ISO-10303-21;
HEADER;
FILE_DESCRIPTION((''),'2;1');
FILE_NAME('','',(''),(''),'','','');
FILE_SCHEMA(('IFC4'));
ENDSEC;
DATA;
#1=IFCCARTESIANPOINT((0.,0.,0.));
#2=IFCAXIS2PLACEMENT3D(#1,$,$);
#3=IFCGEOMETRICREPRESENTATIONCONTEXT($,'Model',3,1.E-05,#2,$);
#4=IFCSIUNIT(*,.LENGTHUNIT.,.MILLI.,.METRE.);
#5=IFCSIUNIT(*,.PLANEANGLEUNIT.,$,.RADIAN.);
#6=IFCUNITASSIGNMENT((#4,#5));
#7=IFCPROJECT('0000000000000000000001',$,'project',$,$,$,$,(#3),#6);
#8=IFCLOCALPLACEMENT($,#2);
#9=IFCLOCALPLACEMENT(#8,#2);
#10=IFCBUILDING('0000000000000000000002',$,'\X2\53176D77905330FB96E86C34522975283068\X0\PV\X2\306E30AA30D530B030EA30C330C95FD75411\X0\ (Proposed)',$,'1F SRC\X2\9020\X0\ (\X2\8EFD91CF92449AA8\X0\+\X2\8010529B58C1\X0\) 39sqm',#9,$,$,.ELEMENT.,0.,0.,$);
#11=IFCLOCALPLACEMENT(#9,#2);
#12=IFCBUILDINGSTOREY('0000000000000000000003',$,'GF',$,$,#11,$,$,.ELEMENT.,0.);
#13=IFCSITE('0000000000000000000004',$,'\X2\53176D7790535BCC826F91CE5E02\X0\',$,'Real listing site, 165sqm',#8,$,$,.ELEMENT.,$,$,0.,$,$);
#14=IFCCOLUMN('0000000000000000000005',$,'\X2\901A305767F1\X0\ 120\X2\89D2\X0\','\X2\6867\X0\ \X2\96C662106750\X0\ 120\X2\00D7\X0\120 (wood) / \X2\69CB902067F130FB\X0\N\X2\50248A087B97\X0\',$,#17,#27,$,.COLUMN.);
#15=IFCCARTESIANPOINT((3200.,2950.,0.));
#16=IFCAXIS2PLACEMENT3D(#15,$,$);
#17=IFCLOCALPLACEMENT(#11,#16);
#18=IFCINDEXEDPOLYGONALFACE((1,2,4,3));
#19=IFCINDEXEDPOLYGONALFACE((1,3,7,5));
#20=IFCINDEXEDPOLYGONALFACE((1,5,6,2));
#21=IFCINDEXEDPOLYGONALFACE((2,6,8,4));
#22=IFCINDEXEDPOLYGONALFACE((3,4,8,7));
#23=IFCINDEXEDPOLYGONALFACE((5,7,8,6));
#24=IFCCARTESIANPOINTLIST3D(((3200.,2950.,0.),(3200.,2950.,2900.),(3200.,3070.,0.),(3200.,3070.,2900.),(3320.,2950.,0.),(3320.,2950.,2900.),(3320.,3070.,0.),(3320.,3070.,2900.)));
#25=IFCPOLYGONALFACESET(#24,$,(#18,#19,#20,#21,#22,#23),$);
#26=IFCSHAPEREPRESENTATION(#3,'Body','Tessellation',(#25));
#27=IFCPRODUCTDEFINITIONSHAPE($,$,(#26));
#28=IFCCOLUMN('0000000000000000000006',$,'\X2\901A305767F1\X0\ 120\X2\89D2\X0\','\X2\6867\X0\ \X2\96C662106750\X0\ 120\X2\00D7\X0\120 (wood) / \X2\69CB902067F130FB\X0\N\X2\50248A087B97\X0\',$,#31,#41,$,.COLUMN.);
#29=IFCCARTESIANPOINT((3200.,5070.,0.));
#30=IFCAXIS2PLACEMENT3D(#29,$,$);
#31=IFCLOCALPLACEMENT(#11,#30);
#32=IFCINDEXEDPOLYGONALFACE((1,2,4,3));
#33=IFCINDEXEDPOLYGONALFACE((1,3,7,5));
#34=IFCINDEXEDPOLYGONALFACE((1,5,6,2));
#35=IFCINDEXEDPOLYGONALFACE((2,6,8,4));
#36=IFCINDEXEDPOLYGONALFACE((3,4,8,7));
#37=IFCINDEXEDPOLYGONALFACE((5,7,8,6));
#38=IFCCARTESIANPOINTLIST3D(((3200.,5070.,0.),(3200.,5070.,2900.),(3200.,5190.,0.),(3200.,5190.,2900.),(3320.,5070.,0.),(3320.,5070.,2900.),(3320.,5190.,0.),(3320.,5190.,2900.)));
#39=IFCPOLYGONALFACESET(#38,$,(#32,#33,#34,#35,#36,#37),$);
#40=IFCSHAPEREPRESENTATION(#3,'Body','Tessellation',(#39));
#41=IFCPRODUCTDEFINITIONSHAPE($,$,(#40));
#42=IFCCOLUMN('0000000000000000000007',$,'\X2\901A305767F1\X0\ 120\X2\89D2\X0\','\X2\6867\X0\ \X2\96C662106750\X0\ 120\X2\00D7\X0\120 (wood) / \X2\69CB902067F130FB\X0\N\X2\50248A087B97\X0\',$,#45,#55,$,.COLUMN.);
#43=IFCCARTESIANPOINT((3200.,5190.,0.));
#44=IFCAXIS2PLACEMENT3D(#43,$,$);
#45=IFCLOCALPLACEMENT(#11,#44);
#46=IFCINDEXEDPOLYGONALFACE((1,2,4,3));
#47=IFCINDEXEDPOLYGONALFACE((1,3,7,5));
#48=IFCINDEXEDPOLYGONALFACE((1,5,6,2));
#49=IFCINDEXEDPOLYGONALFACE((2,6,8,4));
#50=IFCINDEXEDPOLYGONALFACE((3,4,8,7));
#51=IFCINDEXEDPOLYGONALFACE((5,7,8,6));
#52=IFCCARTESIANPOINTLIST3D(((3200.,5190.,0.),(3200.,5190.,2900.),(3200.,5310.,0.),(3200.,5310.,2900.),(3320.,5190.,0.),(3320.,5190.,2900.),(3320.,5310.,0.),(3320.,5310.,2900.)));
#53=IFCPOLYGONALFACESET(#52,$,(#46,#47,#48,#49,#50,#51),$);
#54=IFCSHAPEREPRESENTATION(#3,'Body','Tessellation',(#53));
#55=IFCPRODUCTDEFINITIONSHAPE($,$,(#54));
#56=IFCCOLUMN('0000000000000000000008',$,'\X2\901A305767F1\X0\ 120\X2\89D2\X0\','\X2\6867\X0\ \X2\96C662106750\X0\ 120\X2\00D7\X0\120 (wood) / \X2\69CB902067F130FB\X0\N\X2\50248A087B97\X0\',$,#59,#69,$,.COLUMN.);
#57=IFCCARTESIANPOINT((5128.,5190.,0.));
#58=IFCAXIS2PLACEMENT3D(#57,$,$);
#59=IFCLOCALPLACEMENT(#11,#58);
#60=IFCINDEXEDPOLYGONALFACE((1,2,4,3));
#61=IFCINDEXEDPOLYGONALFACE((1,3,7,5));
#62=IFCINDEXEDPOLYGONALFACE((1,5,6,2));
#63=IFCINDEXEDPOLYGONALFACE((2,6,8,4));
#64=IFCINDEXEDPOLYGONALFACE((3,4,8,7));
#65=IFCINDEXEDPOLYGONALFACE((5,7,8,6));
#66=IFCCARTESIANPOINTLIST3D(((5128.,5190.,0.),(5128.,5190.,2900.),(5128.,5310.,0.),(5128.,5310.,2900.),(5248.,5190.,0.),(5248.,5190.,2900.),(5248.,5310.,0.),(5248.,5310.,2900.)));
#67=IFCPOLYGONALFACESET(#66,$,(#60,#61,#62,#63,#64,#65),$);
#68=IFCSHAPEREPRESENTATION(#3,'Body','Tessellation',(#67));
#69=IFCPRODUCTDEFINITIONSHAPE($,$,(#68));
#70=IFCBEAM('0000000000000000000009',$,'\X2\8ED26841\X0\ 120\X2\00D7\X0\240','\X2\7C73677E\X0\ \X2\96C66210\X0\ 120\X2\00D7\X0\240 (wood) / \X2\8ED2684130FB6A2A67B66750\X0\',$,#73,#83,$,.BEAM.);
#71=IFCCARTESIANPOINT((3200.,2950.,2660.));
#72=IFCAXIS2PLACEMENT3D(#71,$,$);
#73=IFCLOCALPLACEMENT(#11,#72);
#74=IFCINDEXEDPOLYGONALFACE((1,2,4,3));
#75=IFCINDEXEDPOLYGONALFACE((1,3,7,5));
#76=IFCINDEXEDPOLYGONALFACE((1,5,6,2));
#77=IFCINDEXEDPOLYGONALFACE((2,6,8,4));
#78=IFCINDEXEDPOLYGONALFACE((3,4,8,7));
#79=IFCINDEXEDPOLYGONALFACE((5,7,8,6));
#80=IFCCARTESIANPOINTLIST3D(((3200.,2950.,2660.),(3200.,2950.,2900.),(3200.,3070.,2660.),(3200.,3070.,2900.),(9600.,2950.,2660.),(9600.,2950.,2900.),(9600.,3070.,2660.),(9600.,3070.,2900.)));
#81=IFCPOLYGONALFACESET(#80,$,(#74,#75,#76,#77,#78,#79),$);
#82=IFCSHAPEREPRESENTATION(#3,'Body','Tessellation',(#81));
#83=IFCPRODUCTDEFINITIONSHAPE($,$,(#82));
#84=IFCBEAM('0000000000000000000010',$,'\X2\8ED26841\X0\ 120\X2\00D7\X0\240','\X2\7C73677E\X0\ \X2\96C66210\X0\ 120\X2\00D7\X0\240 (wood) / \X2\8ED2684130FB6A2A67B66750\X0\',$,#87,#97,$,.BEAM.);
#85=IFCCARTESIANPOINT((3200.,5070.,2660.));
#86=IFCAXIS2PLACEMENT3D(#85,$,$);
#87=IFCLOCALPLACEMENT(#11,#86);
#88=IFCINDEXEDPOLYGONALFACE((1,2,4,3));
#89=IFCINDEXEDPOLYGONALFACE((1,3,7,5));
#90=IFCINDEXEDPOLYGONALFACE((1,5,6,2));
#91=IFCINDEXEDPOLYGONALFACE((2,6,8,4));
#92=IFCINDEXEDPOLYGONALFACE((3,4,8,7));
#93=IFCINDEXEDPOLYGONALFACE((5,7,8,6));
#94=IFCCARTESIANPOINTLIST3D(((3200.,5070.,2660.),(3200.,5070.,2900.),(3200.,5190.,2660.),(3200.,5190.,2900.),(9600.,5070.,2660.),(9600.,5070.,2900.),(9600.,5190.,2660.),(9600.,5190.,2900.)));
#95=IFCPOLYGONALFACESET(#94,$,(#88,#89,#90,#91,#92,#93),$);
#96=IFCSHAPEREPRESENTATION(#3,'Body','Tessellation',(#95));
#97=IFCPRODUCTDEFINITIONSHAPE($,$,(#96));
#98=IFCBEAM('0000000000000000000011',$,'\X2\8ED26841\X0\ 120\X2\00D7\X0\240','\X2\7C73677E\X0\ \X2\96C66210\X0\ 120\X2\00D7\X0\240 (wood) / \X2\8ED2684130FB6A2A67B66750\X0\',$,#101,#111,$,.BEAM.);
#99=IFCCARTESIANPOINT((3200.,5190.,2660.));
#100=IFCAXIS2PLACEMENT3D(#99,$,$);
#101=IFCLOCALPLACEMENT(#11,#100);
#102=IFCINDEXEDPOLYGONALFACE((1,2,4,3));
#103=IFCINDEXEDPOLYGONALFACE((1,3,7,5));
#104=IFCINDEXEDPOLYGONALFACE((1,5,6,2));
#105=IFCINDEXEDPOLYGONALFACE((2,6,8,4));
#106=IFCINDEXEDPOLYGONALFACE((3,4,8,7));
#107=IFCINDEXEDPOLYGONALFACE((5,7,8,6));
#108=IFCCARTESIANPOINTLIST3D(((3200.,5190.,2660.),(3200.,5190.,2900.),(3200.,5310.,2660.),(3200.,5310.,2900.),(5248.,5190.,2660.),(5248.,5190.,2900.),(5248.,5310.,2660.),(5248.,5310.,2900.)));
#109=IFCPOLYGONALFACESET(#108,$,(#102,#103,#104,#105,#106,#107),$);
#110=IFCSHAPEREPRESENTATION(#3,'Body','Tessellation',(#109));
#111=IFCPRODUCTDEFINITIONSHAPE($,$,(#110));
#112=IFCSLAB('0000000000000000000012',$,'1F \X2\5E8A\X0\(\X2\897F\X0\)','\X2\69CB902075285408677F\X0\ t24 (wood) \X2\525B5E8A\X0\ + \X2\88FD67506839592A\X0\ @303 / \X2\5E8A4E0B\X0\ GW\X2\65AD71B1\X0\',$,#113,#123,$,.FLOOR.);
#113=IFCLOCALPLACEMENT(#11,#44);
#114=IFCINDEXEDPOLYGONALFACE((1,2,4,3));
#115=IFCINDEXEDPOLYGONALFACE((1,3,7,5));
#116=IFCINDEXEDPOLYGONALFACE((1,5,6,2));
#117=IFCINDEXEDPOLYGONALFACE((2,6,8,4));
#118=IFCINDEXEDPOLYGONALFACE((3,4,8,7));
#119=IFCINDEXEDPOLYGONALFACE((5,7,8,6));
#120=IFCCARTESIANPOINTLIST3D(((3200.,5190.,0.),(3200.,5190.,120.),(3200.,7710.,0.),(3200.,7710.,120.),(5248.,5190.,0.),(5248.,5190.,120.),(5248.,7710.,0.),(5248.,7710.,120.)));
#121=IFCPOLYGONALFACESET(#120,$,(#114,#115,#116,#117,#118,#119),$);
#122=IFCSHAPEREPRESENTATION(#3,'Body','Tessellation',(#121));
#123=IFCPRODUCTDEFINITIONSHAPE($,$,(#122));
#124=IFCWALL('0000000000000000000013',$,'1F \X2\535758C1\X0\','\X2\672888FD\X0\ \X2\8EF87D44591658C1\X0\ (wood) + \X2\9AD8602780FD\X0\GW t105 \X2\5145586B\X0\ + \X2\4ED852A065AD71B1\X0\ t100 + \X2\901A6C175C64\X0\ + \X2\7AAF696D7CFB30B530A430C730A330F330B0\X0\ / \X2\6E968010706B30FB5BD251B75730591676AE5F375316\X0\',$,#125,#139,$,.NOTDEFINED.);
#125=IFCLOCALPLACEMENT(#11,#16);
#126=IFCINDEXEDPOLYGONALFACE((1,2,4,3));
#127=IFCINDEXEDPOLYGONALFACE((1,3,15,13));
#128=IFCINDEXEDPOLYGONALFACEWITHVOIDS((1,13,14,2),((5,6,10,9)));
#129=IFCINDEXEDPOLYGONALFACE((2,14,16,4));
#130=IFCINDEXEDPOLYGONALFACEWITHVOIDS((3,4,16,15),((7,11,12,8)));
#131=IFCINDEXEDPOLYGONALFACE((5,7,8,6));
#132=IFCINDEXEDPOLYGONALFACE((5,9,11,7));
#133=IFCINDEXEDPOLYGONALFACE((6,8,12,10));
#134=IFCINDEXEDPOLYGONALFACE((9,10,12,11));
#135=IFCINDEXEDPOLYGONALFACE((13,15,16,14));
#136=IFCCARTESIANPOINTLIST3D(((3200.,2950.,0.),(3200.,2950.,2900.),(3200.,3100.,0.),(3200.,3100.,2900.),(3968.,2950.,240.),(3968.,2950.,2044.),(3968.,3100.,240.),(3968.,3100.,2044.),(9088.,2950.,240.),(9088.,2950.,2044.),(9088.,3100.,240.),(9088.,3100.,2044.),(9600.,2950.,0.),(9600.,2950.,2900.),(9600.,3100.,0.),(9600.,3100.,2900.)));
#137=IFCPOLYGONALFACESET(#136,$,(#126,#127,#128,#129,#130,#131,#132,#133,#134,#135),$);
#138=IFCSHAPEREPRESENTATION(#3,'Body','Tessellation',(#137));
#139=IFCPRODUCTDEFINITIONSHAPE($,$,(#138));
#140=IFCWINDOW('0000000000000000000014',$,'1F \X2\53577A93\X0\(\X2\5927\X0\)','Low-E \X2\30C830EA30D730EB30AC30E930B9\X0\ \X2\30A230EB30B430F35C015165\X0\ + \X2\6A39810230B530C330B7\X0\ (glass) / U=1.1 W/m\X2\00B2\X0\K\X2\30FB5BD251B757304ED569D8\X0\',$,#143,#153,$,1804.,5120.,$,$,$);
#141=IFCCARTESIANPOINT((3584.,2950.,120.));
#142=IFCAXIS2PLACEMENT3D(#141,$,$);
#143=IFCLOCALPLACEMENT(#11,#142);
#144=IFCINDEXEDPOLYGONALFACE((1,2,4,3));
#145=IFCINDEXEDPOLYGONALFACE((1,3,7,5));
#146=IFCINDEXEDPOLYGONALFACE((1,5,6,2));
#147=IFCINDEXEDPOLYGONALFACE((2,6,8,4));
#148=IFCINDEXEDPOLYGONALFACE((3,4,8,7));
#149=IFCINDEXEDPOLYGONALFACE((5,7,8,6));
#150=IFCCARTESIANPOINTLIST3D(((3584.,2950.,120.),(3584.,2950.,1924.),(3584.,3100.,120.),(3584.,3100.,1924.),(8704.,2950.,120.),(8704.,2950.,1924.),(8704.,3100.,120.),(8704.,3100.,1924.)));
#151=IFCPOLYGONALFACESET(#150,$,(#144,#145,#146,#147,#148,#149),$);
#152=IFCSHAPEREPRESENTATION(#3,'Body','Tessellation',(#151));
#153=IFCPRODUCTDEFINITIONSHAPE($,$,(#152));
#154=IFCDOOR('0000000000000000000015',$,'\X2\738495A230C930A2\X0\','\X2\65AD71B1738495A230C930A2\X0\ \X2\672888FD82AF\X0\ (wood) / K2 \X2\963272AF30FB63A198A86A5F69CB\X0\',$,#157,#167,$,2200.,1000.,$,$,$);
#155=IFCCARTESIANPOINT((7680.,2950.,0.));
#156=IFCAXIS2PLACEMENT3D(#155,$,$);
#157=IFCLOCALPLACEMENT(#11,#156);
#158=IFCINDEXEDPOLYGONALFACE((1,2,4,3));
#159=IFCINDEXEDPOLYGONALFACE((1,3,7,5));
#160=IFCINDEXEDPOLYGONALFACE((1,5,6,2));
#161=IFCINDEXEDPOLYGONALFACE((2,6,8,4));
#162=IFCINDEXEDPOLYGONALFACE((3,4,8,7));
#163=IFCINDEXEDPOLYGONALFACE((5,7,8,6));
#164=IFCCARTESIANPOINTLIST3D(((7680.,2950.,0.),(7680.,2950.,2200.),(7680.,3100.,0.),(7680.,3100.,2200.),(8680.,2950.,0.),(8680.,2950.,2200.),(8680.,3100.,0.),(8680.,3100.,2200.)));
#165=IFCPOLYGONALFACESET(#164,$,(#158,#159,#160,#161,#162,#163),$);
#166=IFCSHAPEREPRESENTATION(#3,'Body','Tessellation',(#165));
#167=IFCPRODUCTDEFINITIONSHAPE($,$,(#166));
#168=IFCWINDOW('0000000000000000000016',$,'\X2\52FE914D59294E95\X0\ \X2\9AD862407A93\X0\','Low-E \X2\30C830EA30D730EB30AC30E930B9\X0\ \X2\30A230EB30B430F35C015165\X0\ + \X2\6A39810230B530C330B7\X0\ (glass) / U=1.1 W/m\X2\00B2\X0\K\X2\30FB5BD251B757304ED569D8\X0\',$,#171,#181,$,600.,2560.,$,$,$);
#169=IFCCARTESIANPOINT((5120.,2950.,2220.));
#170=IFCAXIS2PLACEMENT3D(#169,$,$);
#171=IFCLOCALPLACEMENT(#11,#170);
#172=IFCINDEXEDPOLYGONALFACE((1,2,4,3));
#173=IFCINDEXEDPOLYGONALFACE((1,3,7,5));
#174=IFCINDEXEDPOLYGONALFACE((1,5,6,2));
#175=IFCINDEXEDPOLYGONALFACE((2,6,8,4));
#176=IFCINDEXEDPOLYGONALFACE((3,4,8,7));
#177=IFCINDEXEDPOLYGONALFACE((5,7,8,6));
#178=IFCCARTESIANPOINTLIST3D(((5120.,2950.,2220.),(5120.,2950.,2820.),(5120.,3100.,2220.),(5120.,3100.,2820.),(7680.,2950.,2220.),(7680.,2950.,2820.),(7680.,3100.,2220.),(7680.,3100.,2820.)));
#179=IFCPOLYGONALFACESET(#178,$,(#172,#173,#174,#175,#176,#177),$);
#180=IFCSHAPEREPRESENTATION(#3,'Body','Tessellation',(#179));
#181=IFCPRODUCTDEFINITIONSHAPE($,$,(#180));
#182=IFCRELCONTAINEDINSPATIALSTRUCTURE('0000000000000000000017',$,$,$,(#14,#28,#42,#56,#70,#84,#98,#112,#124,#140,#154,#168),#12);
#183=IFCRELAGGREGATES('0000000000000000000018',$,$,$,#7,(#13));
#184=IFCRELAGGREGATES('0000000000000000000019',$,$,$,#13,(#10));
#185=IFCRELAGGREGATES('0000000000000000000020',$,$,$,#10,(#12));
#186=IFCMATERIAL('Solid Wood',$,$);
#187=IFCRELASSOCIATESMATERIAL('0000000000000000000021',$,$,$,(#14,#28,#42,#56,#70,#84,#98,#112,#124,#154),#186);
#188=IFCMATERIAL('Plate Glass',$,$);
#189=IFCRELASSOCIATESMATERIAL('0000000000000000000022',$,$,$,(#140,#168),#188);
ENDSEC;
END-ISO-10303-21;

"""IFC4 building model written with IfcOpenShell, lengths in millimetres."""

from ifc_helpers import new_model, si_unit, frame, frame_2d, origin, place, context, project, spatial, rectangle, extrude, material, element, fill, save


model = new_model("IFC4")

# Units and contexts
model_context = context("Model", 3, precision=1e-05, world=origin())
ifc_project = project(units=[si_unit("LENGTHUNIT", "METRE", prefix="MILLI"), si_unit("PLANEANGLEUNIT", "RADIAN")], contexts=[model_context])

# Site, building, storey
site_placement = place(None, origin())
site = spatial("IfcSite", under=ifc_project, at=site_placement, Name="北海道富良野市", ObjectType="Real listing site, 165sqm", CompositionType="ELEMENT", RefElevation=0.0)
building_placement = place(site_placement, origin())
building = spatial("IfcBuilding", under=site, at=building_placement, Name="北海道・雨水利用とPVのオフグリッド志向 (Proposed)", ObjectType="1F SRC造 (軽量鉄骨+耐力壁) 39sqm", CompositionType="ELEMENT", ElevationOfRefHeight=0.0, ElevationOfTerrain=0.0)
storey_placement = place(building_placement, origin())
storey = spatial("IfcBuildingStorey", under=building, at=storey_placement, Name="GF", CompositionType="ELEMENT", Elevation=0.0)

# Columns
ifc_material_1 = material(Name="Solid Wood")
column_1_placement = place(storey_placement, frame((3200.0, 2950.0, 0.0)))
element("IfcColumn", 1, at=column_1_placement, inside=storey, material=ifc_material_1, Name="通し柱 120角", Description="桧 集成材 120×120 (wood) / 構造柱・N値計算", PredefinedType="COLUMN", context=model_context, shape_type="SweptSolid", body=[
    extrude(rectangle(XDim=120.0, YDim=120.0, at=frame_2d((60.0, 60.0))), frame((3200.0, 2950.0, 0.0)), (0.0, 0.0, 1.0), 2900.0),
])
column_2_placement = place(storey_placement, frame((3200.0, 5070.0, 0.0)))
element("IfcColumn", 2, at=column_2_placement, inside=storey, material=ifc_material_1, Name="通し柱 120角", Description="桧 集成材 120×120 (wood) / 構造柱・N値計算", PredefinedType="COLUMN", context=model_context, shape_type="SweptSolid", body=[
    extrude(rectangle(XDim=120.0, YDim=120.0, at=frame_2d((60.0, 60.0))), frame((3200.0, 5070.0, 0.0)), (0.0, 0.0, 1.0), 2900.0),
])
column_3_placement = place(storey_placement, frame((3200.0, 5190.0, 0.0)))
element("IfcColumn", 3, at=column_3_placement, inside=storey, material=ifc_material_1, Name="通し柱 120角", Description="桧 集成材 120×120 (wood) / 構造柱・N値計算", PredefinedType="COLUMN", context=model_context, shape_type="SweptSolid", body=[
    extrude(rectangle(XDim=120.0, YDim=120.0, at=frame_2d((60.0, 60.0))), frame((3200.0, 5190.0, 0.0)), (0.0, 0.0, 1.0), 2900.0),
])
column_4_placement = place(storey_placement, frame((5128.0, 5190.0, 0.0)))
element("IfcColumn", 4, at=column_4_placement, inside=storey, material=ifc_material_1, Name="通し柱 120角", Description="桧 集成材 120×120 (wood) / 構造柱・N値計算", PredefinedType="COLUMN", context=model_context, shape_type="SweptSolid", body=[
    extrude(rectangle(XDim=120.0, YDim=120.0, at=frame_2d((60.0, 60.0))), frame((5128.0, 5190.0, 0.0)), (0.0, 0.0, 1.0), 2900.0),
])

# Beams
beam_1_placement = place(storey_placement, frame((3200.0, 2950.0, 2660.0)))
element("IfcBeam", 5, at=beam_1_placement, inside=storey, material=ifc_material_1, Name="軒桁 120×240", Description="米松 集成 120×240 (wood) / 軒桁・横架材", PredefinedType="BEAM", context=model_context, shape_type="SweptSolid", body=[
    extrude(rectangle(XDim=6400.0, YDim=120.0, at=frame_2d((3200.0, 60.0))), frame((3200.0, 2950.0, 2660.0)), (0.0, 0.0, 1.0), 240.0),
])
beam_2_placement = place(storey_placement, frame((3200.0, 5070.0, 2660.0)))
element("IfcBeam", 6, at=beam_2_placement, inside=storey, material=ifc_material_1, Name="軒桁 120×240", Description="米松 集成 120×240 (wood) / 軒桁・横架材", PredefinedType="BEAM", context=model_context, shape_type="SweptSolid", body=[
    extrude(rectangle(XDim=6400.0, YDim=120.0, at=frame_2d((3200.0, 60.0))), frame((3200.0, 5070.0, 2660.0)), (0.0, 0.0, 1.0), 240.0),
])
beam_3_placement = place(storey_placement, frame((3200.0, 5190.0, 2660.0)))
element("IfcBeam", 7, at=beam_3_placement, inside=storey, material=ifc_material_1, Name="軒桁 120×240", Description="米松 集成 120×240 (wood) / 軒桁・横架材", PredefinedType="BEAM", context=model_context, shape_type="SweptSolid", body=[
    extrude(rectangle(XDim=2048.0, YDim=120.0, at=frame_2d((1024.0, 60.0))), frame((3200.0, 5190.0, 2660.0)), (0.0, 0.0, 1.0), 240.0),
])

# Slab
slab_1_placement = place(storey_placement, frame((3200.0, 5190.0, 0.0)))
element("IfcSlab", 8, at=slab_1_placement, inside=storey, material=ifc_material_1, Name="1F 床(西)", Description="構造用合板 t24 (wood) 剛床 + 製材根太 @303 / 床下 GW断熱", PredefinedType="FLOOR", context=model_context, shape_type="SweptSolid", body=[
    extrude(rectangle(XDim=2048.0, YDim=2520.0, at=frame_2d((1024.0, 1260.0))), frame((3200.0, 5190.0, 0.0)), (0.0, 0.0, 1.0), 120.0),
])

# Wall, openings, windows, door
wall_1_placement = place(storey_placement, frame((3200.0, 2950.0, 0.0)))
wall_1 = element("IfcWall", 9, at=wall_1_placement, inside=storey, material=ifc_material_1, Name="1F 南壁", Description="木製 軸組外壁 (wood) + 高性能GW t105 充填 + 付加断熱 t100 + 通気層 + 窯業系サイディング / 準耐火・寒冷地外皮強化", PredefinedType="NOTDEFINED", context=model_context, shape_type="SweptSolid", body=[
    extrude(rectangle(XDim=6400.0, YDim=150.0, at=frame_2d((3200.0, 75.0))), frame((3200.0, 2950.0, 0.0)), (0.0, 0.0, 1.0), 2900.0),
])
opening_1_placement = place(storey_placement, frame((3584.0, 2950.0, 120.0)))
opening_1 = element("IfcOpeningElement", 10, at=opening_1_placement, cuts=wall_1, PredefinedType="NOTDEFINED", context=model_context, shape_type="SweptSolid", body=[
    extrude(rectangle(XDim=5120.0, YDim=150.0, at=frame_2d((2560.0, 75.0))), frame((3584.0, 2950.0, 120.0)), (0.0, 0.0, 1.0), 1804.0),
])
opening_2_placement = place(storey_placement, frame((7680.0, 2950.0, 0.0)))
opening_2 = element("IfcOpeningElement", 11, at=opening_2_placement, cuts=wall_1, PredefinedType="NOTDEFINED", context=model_context, shape_type="SweptSolid", body=[
    extrude(rectangle(XDim=1000.0, YDim=150.0, at=frame_2d((500.0, 75.0))), frame((7680.0, 2950.0, 0.0)), (0.0, 0.0, 1.0), 2200.0),
])
opening_3_placement = place(storey_placement, frame((5120.0, 2950.0, 2220.0)))
opening_3 = element("IfcOpeningElement", 12, at=opening_3_placement, cuts=wall_1, PredefinedType="NOTDEFINED", context=model_context, shape_type="SweptSolid", body=[
    extrude(rectangle(XDim=2560.0, YDim=150.0, at=frame_2d((1280.0, 75.0))), frame((5120.0, 2950.0, 2220.0)), (0.0, 0.0, 1.0), 600.0),
])
ifc_material_2 = material(Name="Plate Glass")
window_1_placement = place(storey_placement, frame((3584.0, 2950.0, 120.0)))
window_1 = element("IfcWindow", 13, at=window_1_placement, inside=storey, material=ifc_material_2, Name="1F 南窓(大)", Description="Low-E トリプルガラス アルゴン封入 + 樹脂サッシ (glass) / U=1.1 W/m²K・寒冷地仕様", OverallHeight=1804.0, OverallWidth=5120.0, context=model_context, shape_type="SweptSolid", body=[
    extrude(rectangle(XDim=5120.0, YDim=150.0, at=frame_2d((2560.0, 75.0))), frame((3584.0, 2950.0, 120.0)), (0.0, 0.0, 1.0), 1804.0),
])
fill(opening_1, window_1)
door_placement = place(storey_placement, frame((7680.0, 2950.0, 0.0)))
door = element("IfcDoor", 14, at=door_placement, inside=storey, material=ifc_material_1, Name="玄関ドア", Description="断熱玄関ドア 木製芯 (wood) / K2 防犯・採風機構", OverallHeight=2200.0, OverallWidth=1000.0, context=model_context, shape_type="SweptSolid", body=[
    extrude(rectangle(XDim=1000.0, YDim=150.0, at=frame_2d((500.0, 75.0))), frame((7680.0, 2950.0, 0.0)), (0.0, 0.0, 1.0), 2200.0),
])
fill(opening_2, door)
window_2_placement = place(storey_placement, frame((5120.0, 2950.0, 2220.0)))
window_2 = element("IfcWindow", 15, at=window_2_placement, inside=storey, material=ifc_material_2, Name="勾配天井 高所窓", Description="Low-E トリプルガラス アルゴン封入 + 樹脂サッシ (glass) / U=1.1 W/m²K・寒冷地仕様", OverallHeight=600.0, OverallWidth=2560.0, context=model_context, shape_type="SweptSolid", body=[
    extrude(rectangle(XDim=2560.0, YDim=150.0, at=frame_2d((1280.0, 75.0))), frame((5120.0, 2950.0, 2220.0)), (0.0, 0.0, 1.0), 600.0),
])
fill(opening_3, window_2)

save(model, "model.ifc")
